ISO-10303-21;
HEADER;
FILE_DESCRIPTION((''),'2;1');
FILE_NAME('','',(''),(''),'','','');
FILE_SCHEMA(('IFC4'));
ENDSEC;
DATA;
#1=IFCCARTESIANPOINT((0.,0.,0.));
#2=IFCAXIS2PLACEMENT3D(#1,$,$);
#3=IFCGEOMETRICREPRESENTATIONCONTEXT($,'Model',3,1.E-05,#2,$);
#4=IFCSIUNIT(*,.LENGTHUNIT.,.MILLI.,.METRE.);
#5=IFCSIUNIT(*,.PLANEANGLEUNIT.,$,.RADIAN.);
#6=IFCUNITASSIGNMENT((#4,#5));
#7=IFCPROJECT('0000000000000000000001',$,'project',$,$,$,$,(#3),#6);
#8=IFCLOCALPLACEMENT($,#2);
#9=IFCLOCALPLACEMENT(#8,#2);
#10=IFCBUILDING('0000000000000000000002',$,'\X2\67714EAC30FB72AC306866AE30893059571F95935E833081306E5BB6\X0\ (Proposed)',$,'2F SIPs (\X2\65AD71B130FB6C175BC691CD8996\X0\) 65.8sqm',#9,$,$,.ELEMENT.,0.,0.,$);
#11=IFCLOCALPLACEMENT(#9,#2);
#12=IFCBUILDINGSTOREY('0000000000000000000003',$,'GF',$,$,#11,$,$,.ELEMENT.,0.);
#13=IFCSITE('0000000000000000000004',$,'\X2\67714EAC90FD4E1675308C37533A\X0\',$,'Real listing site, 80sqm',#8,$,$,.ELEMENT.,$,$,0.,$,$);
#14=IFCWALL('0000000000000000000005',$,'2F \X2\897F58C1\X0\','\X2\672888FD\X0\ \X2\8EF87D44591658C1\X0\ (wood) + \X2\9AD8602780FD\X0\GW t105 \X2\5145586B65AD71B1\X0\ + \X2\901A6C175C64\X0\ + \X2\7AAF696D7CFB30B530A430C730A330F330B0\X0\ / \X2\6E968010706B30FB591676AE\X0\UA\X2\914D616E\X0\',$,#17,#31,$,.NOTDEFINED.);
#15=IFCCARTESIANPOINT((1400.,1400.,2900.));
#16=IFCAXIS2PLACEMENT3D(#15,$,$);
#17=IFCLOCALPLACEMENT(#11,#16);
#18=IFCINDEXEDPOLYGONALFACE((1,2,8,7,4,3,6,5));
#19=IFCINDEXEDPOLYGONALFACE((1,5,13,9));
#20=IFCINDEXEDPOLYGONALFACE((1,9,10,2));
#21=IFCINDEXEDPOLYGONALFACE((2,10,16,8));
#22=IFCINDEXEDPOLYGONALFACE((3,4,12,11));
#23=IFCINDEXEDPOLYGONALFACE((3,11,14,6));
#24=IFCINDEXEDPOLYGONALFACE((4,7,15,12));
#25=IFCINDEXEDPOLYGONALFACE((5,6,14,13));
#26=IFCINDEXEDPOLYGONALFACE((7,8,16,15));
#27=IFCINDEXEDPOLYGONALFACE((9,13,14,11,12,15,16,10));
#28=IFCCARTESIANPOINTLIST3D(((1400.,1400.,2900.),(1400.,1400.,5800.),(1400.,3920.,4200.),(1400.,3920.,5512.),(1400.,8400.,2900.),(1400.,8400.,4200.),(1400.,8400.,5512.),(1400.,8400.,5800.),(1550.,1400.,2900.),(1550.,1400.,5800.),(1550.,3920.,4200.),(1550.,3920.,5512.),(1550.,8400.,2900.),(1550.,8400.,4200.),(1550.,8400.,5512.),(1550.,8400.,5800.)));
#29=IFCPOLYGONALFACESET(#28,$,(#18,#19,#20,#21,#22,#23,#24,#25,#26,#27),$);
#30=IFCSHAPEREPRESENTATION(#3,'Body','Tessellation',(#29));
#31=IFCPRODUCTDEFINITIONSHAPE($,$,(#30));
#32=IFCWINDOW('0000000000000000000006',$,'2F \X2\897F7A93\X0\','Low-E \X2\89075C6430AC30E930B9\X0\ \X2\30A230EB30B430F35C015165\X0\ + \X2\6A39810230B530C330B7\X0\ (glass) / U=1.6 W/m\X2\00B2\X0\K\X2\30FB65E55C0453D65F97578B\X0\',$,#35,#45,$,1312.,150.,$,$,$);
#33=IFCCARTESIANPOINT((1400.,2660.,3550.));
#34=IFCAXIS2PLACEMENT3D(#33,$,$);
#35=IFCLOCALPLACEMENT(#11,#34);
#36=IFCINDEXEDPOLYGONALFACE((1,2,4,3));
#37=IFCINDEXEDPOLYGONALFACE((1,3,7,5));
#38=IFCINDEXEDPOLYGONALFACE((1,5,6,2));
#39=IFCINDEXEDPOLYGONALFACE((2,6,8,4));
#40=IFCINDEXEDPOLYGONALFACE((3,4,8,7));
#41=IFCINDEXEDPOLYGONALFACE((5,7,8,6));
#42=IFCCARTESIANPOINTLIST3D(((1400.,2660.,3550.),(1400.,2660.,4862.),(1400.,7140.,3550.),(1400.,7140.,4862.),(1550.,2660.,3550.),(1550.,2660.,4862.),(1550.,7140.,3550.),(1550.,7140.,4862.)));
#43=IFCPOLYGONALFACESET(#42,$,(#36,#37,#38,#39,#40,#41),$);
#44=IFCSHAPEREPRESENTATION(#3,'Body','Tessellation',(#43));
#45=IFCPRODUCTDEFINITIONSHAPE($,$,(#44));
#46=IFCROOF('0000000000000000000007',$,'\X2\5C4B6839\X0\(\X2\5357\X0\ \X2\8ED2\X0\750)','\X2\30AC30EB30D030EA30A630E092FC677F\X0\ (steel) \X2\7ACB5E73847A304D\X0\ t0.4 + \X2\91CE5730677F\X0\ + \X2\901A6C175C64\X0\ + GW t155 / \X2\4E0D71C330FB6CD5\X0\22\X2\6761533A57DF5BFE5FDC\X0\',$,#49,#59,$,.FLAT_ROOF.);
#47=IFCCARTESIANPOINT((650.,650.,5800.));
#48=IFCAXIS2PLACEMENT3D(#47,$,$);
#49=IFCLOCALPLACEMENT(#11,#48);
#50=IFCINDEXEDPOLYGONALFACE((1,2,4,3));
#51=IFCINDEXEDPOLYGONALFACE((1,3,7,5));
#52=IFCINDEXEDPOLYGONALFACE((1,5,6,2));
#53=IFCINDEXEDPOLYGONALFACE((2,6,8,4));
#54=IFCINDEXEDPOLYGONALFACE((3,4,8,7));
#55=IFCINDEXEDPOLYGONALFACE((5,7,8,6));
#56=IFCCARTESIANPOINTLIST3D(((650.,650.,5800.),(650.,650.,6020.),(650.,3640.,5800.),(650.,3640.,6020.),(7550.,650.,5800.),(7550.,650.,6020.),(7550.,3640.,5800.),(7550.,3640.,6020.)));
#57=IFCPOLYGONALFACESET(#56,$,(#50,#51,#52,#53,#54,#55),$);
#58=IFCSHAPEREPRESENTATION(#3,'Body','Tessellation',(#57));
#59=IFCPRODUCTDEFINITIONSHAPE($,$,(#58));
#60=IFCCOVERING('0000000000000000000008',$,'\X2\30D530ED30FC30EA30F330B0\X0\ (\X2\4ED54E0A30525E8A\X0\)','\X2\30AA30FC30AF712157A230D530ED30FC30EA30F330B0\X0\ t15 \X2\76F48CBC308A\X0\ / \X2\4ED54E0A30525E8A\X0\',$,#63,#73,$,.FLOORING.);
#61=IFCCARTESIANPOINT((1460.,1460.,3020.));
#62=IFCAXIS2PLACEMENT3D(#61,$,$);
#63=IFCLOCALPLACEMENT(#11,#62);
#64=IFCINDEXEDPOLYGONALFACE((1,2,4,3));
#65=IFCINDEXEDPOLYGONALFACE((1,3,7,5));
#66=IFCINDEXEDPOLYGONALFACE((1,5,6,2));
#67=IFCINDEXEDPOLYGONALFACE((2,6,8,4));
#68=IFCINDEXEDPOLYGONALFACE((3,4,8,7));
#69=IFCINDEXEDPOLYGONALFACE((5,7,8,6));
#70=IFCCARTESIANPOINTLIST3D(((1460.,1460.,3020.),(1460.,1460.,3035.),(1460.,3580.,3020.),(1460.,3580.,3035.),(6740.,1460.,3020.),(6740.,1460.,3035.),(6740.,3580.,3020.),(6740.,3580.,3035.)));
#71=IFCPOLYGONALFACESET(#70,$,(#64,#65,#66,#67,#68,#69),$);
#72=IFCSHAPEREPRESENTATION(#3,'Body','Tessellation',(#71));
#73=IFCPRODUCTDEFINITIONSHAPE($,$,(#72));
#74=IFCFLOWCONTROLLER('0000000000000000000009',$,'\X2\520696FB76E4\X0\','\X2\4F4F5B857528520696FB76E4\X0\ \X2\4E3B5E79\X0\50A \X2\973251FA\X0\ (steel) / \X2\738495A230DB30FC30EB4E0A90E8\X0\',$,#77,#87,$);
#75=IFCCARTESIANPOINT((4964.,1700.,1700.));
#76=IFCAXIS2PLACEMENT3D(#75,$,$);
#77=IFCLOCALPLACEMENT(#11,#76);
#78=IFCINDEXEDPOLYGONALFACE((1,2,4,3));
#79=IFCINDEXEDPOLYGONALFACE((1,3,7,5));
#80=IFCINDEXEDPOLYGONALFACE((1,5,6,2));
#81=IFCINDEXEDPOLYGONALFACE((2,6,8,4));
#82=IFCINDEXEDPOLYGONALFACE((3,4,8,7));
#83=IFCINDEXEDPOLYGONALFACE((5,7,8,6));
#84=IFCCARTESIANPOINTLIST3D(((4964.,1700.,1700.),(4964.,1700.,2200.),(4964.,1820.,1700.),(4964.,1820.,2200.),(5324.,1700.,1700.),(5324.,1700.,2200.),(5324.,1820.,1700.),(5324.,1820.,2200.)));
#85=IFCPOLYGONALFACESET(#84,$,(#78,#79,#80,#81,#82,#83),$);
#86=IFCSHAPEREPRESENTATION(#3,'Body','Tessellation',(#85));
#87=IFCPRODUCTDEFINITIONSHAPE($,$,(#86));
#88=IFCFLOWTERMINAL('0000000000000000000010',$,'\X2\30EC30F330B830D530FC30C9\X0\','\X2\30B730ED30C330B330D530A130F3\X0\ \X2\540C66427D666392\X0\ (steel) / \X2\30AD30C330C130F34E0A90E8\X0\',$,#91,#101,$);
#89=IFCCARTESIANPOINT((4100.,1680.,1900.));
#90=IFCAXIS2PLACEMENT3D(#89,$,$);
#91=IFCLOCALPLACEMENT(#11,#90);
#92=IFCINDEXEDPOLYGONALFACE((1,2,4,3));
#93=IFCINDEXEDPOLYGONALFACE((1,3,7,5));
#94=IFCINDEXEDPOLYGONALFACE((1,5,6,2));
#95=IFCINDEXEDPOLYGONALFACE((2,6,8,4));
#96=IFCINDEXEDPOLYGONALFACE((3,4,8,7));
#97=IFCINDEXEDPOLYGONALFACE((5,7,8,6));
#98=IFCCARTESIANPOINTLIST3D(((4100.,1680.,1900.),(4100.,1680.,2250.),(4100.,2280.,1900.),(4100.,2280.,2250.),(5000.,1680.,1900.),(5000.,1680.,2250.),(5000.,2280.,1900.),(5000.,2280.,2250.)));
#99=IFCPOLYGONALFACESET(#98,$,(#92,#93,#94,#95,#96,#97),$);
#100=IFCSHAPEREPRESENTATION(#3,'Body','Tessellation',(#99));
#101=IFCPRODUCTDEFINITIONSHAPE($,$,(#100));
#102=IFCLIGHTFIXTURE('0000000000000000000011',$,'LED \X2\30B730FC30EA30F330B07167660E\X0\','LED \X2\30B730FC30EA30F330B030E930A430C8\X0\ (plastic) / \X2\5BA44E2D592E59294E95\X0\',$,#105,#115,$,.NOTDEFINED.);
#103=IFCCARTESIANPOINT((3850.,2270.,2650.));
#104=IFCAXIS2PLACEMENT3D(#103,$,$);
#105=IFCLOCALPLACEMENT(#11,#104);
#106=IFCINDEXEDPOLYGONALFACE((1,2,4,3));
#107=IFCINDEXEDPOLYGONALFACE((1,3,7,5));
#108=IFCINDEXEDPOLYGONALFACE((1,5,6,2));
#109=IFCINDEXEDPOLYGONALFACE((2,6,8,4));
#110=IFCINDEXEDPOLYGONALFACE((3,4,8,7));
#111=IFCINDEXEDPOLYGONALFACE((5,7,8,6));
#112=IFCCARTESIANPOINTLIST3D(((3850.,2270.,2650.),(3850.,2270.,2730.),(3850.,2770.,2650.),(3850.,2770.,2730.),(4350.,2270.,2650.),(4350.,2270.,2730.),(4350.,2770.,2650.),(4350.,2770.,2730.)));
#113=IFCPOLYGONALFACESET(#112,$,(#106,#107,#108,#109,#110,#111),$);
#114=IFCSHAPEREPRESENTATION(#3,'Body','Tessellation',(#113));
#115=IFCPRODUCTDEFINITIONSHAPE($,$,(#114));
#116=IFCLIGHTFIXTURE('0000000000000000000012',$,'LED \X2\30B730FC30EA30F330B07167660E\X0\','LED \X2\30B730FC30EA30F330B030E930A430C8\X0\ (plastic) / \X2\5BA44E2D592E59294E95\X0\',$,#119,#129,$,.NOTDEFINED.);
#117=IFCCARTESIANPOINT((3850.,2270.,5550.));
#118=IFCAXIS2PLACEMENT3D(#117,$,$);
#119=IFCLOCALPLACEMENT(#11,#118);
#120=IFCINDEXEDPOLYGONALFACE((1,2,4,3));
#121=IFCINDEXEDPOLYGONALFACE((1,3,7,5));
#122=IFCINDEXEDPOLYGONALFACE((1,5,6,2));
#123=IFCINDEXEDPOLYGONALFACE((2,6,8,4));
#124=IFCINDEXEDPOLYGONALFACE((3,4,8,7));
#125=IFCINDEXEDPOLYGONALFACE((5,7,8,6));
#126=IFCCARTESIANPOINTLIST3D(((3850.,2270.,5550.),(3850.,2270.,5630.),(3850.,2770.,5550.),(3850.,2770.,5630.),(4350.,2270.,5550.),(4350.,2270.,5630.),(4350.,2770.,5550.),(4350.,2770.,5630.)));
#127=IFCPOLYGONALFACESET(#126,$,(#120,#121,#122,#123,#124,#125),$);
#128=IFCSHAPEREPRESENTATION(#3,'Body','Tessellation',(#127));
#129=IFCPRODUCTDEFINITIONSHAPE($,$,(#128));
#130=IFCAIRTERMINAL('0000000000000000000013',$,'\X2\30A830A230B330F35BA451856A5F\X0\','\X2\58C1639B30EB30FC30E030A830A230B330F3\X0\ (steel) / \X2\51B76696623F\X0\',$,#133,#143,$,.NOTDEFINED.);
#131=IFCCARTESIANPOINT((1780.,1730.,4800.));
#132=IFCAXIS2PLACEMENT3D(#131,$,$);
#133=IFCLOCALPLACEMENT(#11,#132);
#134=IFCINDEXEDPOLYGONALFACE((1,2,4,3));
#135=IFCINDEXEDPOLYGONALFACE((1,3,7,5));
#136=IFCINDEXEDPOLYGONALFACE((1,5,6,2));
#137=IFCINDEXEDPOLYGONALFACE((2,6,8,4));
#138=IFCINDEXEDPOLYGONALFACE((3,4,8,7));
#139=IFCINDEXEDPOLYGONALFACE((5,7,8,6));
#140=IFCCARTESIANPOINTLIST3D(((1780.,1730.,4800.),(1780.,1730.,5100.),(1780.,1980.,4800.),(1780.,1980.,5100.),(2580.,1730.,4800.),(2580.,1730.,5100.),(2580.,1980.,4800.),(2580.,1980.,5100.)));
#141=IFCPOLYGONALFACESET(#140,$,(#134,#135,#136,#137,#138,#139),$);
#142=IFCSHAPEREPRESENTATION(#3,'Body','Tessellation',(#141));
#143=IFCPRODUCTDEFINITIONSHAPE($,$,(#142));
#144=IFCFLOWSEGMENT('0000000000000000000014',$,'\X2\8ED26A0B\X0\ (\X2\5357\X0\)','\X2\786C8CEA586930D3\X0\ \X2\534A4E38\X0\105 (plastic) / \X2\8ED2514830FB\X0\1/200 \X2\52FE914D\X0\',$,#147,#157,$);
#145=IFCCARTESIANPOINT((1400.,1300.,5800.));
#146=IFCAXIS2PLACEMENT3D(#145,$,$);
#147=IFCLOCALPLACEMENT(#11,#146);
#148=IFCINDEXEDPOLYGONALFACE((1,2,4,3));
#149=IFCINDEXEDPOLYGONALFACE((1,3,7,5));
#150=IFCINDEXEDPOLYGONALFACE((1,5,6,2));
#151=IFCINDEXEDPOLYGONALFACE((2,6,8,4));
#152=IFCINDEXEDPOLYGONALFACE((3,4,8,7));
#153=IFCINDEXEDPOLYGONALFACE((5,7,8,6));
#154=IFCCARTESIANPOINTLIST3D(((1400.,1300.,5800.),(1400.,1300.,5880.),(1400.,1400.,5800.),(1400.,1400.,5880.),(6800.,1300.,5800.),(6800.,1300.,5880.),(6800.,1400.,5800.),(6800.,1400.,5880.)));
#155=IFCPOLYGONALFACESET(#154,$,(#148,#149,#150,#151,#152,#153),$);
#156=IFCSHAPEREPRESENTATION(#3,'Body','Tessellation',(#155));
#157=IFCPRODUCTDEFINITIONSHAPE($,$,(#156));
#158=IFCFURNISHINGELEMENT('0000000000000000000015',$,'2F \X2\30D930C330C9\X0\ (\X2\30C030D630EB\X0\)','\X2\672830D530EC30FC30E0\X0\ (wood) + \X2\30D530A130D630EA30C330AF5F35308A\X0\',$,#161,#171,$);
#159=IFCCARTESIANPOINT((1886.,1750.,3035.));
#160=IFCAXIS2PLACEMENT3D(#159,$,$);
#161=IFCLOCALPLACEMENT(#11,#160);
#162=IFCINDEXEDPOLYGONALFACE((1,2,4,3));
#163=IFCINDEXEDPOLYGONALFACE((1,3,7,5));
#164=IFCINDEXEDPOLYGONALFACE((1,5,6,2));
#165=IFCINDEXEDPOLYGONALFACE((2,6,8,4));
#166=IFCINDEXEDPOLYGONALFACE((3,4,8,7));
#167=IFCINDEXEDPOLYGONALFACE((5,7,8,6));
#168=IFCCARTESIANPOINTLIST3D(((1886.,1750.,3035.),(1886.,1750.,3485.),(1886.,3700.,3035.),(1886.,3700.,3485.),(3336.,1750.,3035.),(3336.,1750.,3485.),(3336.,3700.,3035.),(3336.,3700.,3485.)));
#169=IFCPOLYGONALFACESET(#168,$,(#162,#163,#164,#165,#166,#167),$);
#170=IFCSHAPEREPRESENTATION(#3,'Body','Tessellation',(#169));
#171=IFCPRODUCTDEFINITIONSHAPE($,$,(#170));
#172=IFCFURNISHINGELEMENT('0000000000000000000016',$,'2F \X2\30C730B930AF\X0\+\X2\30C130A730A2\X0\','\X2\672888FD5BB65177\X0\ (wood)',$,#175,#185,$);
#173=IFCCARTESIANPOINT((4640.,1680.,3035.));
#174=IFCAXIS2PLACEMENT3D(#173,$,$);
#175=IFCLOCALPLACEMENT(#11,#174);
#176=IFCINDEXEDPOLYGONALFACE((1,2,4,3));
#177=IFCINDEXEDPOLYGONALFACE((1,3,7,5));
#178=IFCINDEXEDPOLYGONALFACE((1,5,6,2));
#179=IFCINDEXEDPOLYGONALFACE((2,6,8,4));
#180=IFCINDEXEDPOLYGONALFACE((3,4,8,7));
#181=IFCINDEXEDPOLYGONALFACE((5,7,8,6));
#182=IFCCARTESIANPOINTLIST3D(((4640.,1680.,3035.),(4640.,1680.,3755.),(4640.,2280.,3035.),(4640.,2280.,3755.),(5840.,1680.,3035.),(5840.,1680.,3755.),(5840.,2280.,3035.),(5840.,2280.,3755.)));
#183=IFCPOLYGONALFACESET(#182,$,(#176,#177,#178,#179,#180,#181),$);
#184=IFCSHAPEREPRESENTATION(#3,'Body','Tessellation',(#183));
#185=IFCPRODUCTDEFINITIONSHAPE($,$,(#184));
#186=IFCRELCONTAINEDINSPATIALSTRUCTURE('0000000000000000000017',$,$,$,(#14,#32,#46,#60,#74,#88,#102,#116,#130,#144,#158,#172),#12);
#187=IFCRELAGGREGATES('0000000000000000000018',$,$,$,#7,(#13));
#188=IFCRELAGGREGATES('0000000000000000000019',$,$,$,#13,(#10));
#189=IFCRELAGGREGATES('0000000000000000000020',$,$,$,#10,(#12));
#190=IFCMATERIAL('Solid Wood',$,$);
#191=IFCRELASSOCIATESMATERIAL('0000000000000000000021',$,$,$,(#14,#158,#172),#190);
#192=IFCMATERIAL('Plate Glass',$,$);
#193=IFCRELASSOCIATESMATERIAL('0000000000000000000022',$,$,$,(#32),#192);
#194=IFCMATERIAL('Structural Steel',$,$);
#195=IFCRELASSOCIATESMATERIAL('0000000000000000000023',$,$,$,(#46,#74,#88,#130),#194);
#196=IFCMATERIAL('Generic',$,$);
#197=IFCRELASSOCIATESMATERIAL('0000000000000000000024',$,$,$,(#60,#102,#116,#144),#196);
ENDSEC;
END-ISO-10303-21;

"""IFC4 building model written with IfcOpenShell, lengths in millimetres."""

from ifc_helpers import new_model, si_unit, frame, frame_2d, origin, place, context, project, spatial, rectangle, extrude, material, element, fill, save


model = new_model("IFC4")

# Units and contexts
model_context = context("Model", 3, precision=1e-05, world=origin())
ifc_project = project(units=[si_unit("LENGTHUNIT", "METRE", prefix="MILLI"), si_unit("PLANEANGLEUNIT", "RADIAN")], contexts=[model_context])

# Site, building, storey
site_placement = place(None, origin())
site = spatial("IfcSite", under=ifc_project, at=site_placement, Name="東京都世田谷区", ObjectType="Real listing site, 80sqm", CompositionType="ELEMENT", RefElevation=0.0)
building_placement = place(site_placement, origin())
building = spatial("IfcBuilding", under=site, at=building_placement, Name="東京・犬と暮らす土間広めの家 (Proposed)", ObjectType="2F SIPs (断熱・気密重視) 65.8sqm", CompositionType="ELEMENT", ElevationOfRefHeight=0.0, ElevationOfTerrain=0.0)
storey_placement = place(building_placement, origin())
storey = spatial("IfcBuildingStorey", under=building, at=storey_placement, Name="GF", CompositionType="ELEMENT", Elevation=0.0)

# Shared definitions
ifc_material_1 = material(Name="Solid Wood")

# Wall, opening, window
ifc_material_2 = material(Name="Plate Glass")
wall_1_placement = place(storey_placement, frame((1400.0, 1400.0, 2900.0)))
wall_1 = element("IfcWall", 1, at=wall_1_placement, inside=storey, material=ifc_material_1, Name="2F 西壁", Description="木製 軸組外壁 (wood) + 高性能GW t105 充填断熱 + 通気層 + 窯業系サイディング / 準耐火・外皮UA配慮", PredefinedType="NOTDEFINED", context=model_context, shape_type="SweptSolid", body=[
    extrude(rectangle(XDim=150.0, YDim=7000.0, at=frame_2d((75.0, 3500.0))), frame((1400.0, 1400.0, 2900.0)), (0.0, 0.0, 1.0), 2900.0),
])
opening_1_placement = place(storey_placement, frame((1400.0, 2660.0, 3550.0)))
opening_1 = element("IfcOpeningElement", 2, at=opening_1_placement, cuts=wall_1, PredefinedType="NOTDEFINED", context=model_context, shape_type="SweptSolid", body=[
    extrude(rectangle(XDim=150.0, YDim=4480.0, at=frame_2d((75.0, 2240.0))), frame((1400.0, 2660.0, 3550.0)), (0.0, 0.0, 1.0), 1312.0),
])
window_1_placement = place(storey_placement, frame((1400.0, 2660.0, 3550.0)))
window_1 = element("IfcWindow", 3, at=window_1_placement, inside=storey, material=ifc_material_2, Name="2F 西窓", Description="Low-E 複層ガラス アルゴン封入 + 樹脂サッシ (glass) / U=1.6 W/m²K・日射取得型", OverallHeight=1312.0, OverallWidth=150.0, context=model_context, shape_type="SweptSolid", body=[
    extrude(rectangle(XDim=150.0, YDim=4480.0, at=frame_2d((75.0, 2240.0))), frame((1400.0, 2660.0, 3550.0)), (0.0, 0.0, 1.0), 1312.0),
])
fill(opening_1, window_1)

# Roof
ifc_material_3 = material(Name="Structural Steel")
for number, where, name in (
    (4, (650.0, 650.0, 5800.0), "屋根(南 軒750)"),
):
    element("IfcRoof", number, at=place(storey_placement, frame(where)), inside=storey, material=ifc_material_3, Name=name, Description="ガルバリウム鋼板 (steel) 立平葺き t0.4 + 野地板 + 通気層 + GW t155 / 不燃・法22条区域対応", PredefinedType="FLAT_ROOF", context=model_context, shape_type="SweptSolid", body=[
        extrude(rectangle(XDim=6900.0, YDim=2990.0, at=frame_2d((3450.0, 1495.0))), frame((650.0, 650.0, 5800.0)), (0.0, 0.0, 1.0), 220.0),
    ])

# Covering
ifc_material_4 = material(Name="Generic")
covering_placement = place(storey_placement, frame((1460.0, 1460.0, 3020.0)))
element("IfcCovering", 5, at=covering_placement, inside=storey, material=ifc_material_4, Name="フローリング (仕上げ床)", Description="オーク無垢フローリング t15 直貼り / 仕上げ床", PredefinedType="FLOORING", context=model_context, shape_type="SweptSolid", body=[
    extrude(rectangle(XDim=5280.0, YDim=2120.0, at=frame_2d((2640.0, 1060.0))), frame((1460.0, 1460.0, 3020.0)), (0.0, 0.0, 1.0), 15.0),
])

# Flow controller
flow_controller_placement = place(storey_placement, frame((4964.0, 1700.0, 1700.0)))
element("IfcFlowController", 6, at=flow_controller_placement, inside=storey, material=ifc_material_3, Name="分電盤", Description="住宅用分電盤 主幹50A 露出 (steel) / 玄関ホール上部", context=model_context, shape_type="SweptSolid", body=[
    extrude(rectangle(XDim=360.0, YDim=120.0, at=frame_2d((180.0, 60.0))), frame((4964.0, 1700.0, 1700.0)), (0.0, 0.0, 1.0), 500.0),
])

# Flow terminal
flow_terminal_placement = place(storey_placement, frame((4100.0, 1680.0, 1900.0)))
element("IfcFlowTerminal", 7, at=flow_terminal_placement, inside=storey, material=ifc_material_3, Name="レンジフード", Description="シロッコファン 同時給排 (steel) / キッチン上部", context=model_context, shape_type="SweptSolid", body=[
    extrude(rectangle(XDim=900.0, YDim=600.0, at=frame_2d((450.0, 300.0))), frame((4100.0, 1680.0, 1900.0)), (0.0, 0.0, 1.0), 350.0),
])

# Light fixtures
light_fixture_1_placement = place(storey_placement, frame((3850.0, 2270.0, 2650.0)))
element("IfcLightFixture", 8, at=light_fixture_1_placement, inside=storey, material=ifc_material_4, Name="LED シーリング照明", Description="LED シーリングライト (plastic) / 室中央天井", PredefinedType="NOTDEFINED", context=model_context, shape_type="SweptSolid", body=[
    extrude(rectangle(XDim=500.0, YDim=500.0, at=frame_2d((250.0, 250.0))), frame((3850.0, 2270.0, 2650.0)), (0.0, 0.0, 1.0), 80.0),
])
light_fixture_2_placement = place(storey_placement, frame((3850.0, 2270.0, 5550.0)))
element("IfcLightFixture", 9, at=light_fixture_2_placement, inside=storey, material=ifc_material_4, Name="LED シーリング照明", Description="LED シーリングライト (plastic) / 室中央天井", PredefinedType="NOTDEFINED", context=model_context, shape_type="SweptSolid", body=[
    extrude(rectangle(XDim=500.0, YDim=500.0, at=frame_2d((250.0, 250.0))), frame((3850.0, 2270.0, 5550.0)), (0.0, 0.0, 1.0), 80.0),
])

# Air terminal
air_terminal_placement = place(storey_placement, frame((1780.0, 1730.0, 4800.0)))
element("IfcAirTerminal", 10, at=air_terminal_placement, inside=storey, material=ifc_material_3, Name="エアコン室内機", Description="壁掛ルームエアコン (steel) / 冷暖房", PredefinedType="NOTDEFINED", context=model_context, shape_type="SweptSolid", body=[
    extrude(rectangle(XDim=800.0, YDim=250.0, at=frame_2d((400.0, 125.0))), frame((1780.0, 1730.0, 4800.0)), (0.0, 0.0, 1.0), 300.0),
])

# Flow segment
flow_segment_placement = place(storey_placement, frame((1400.0, 1300.0, 5800.0)))
element("IfcFlowSegment", 11, at=flow_segment_placement, inside=storey, material=ifc_material_4, Name="軒樋 (南)", Description="硬質塩ビ 半丸105 (plastic) / 軒先・1/200 勾配", context=model_context, shape_type="SweptSolid", body=[
    extrude(rectangle(XDim=5400.0, YDim=100.0, at=frame_2d((2700.0, 50.0))), frame((1400.0, 1300.0, 5800.0)), (0.0, 0.0, 1.0), 80.0),
])

# Furnishing elements
furnishing_1_placement = place(storey_placement, frame((1886.0, 1750.0, 3035.0)))
element("IfcFurnishingElement", 12, at=furnishing_1_placement, inside=storey, material=ifc_material_1, Name="2F ベッド (ダブル)", Description="木フレーム (wood) + ファブリック張り", context=model_context, shape_type="SweptSolid", body=[
    extrude(rectangle(XDim=1450.0, YDim=1950.0, at=frame_2d((725.0, 975.0))), frame((1886.0, 1750.0, 3035.0)), (0.0, 0.0, 1.0), 450.0),
])
furnishing_2_placement = place(storey_placement, frame((4640.0, 1680.0, 3035.0)))
element("IfcFurnishingElement", 13, at=furnishing_2_placement, inside=storey, material=ifc_material_1, Name="2F デスク+チェア", Description="木製家具 (wood)", context=model_context, shape_type="SweptSolid", body=[
    extrude(rectangle(XDim=1200.0, YDim=600.0, at=frame_2d((600.0, 300.0))), frame((4640.0, 1680.0, 3035.0)), (0.0, 0.0, 1.0), 720.0),
])

save(model, "model.ifc")
